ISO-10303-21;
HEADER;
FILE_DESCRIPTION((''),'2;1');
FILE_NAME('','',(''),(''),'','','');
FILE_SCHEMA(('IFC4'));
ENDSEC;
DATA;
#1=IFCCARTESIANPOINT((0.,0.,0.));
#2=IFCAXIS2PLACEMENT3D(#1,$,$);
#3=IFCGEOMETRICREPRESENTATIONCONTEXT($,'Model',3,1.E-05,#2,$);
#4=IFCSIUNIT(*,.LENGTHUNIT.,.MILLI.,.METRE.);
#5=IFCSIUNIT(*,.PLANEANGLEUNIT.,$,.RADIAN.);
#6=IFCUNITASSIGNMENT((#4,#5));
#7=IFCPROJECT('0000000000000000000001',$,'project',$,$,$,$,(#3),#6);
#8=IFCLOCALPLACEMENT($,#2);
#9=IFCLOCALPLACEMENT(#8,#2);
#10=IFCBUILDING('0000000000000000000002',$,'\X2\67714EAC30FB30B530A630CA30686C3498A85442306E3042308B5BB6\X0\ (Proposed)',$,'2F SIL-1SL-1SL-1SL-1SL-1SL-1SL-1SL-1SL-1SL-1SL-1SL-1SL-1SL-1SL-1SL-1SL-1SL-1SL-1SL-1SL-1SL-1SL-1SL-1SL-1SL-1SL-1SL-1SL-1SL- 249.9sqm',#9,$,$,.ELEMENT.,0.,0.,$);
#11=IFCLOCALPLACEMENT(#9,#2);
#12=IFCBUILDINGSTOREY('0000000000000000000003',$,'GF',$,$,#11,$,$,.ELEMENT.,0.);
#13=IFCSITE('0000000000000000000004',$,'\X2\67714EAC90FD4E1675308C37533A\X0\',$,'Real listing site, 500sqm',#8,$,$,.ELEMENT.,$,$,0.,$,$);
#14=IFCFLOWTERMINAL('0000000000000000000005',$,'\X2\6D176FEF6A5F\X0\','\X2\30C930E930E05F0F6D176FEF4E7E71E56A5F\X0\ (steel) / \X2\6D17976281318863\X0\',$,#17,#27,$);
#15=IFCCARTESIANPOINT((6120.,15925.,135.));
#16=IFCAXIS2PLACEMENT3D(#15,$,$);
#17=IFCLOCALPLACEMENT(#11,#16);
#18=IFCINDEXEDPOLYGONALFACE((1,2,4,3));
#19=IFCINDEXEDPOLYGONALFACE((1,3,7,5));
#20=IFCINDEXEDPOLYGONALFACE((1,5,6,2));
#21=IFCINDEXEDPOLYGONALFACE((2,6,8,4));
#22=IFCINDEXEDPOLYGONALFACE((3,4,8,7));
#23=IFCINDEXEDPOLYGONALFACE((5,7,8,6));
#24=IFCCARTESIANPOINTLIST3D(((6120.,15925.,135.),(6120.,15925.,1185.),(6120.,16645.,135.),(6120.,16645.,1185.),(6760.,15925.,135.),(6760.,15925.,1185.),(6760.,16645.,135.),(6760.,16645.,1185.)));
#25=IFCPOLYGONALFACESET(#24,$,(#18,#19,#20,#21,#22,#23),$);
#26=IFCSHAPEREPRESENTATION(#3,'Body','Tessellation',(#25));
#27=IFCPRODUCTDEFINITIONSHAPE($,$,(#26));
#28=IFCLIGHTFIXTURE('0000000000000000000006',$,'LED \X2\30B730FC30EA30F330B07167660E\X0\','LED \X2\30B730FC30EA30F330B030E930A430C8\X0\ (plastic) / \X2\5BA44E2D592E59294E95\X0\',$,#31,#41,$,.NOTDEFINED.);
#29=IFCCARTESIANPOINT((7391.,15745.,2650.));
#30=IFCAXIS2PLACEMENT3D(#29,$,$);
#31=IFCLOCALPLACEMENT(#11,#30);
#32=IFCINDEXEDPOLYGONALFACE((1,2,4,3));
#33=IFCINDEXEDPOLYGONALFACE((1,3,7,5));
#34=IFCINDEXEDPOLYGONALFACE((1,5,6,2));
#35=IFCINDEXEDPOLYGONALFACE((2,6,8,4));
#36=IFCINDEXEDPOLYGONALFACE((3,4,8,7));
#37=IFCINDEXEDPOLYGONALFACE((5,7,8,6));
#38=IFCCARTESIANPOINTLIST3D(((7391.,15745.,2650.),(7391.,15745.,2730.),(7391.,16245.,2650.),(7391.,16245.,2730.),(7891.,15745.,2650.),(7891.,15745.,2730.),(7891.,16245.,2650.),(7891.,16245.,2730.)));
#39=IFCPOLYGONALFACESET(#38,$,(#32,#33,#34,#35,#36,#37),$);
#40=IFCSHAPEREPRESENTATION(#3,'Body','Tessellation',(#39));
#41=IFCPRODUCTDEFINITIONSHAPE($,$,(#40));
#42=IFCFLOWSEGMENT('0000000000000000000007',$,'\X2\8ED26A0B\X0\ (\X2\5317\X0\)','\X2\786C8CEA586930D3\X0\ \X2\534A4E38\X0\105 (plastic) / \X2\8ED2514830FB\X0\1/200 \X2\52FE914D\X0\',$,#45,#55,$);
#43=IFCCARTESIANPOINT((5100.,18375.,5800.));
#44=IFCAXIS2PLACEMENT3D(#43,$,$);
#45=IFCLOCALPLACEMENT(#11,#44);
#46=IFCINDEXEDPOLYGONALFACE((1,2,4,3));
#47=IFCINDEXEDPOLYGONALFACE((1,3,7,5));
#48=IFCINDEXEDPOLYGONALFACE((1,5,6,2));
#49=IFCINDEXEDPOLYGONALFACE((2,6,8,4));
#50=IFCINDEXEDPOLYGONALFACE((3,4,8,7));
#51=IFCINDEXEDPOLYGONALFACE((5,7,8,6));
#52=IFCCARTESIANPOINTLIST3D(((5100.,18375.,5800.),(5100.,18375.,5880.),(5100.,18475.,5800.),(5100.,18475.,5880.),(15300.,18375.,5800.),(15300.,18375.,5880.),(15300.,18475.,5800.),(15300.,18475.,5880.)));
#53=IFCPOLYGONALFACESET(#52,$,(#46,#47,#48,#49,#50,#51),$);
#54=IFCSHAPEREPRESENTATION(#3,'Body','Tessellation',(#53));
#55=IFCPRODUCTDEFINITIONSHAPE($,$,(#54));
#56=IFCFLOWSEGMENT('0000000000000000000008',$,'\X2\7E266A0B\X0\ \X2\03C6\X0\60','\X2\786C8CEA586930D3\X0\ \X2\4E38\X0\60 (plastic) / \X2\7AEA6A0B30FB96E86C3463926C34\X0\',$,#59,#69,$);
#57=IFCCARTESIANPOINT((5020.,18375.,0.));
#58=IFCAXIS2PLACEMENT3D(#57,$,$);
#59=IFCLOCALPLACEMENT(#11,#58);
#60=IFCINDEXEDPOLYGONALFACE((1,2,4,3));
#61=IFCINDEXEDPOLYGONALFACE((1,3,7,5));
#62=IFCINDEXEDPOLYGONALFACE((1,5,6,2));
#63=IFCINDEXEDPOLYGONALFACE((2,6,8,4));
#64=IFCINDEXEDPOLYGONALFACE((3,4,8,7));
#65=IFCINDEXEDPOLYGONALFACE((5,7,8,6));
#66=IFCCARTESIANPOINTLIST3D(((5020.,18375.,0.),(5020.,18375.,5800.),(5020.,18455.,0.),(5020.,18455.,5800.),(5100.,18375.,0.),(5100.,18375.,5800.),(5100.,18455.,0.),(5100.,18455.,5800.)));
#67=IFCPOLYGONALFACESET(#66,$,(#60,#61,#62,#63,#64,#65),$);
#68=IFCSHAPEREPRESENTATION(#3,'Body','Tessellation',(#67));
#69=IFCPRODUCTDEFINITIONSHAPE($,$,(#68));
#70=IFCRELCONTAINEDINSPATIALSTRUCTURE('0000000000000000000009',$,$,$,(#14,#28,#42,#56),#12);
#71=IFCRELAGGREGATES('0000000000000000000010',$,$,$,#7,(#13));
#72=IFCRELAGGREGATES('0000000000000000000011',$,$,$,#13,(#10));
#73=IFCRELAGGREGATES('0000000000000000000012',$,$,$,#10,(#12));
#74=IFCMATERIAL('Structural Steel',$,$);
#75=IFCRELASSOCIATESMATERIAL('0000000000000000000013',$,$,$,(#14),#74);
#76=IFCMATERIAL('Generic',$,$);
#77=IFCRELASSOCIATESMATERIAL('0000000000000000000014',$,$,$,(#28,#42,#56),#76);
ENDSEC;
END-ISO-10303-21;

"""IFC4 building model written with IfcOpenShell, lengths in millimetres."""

from ifc_helpers import new_model, si_unit, frame, frame_2d, origin, place, context, project, spatial, rectangle, extrude, material, element, save


model = new_model("IFC4")

# Units and contexts
model_context = context("Model", 3, precision=1e-05, world=origin())
ifc_project = project(units=[si_unit("LENGTHUNIT", "METRE", prefix="MILLI"), si_unit("PLANEANGLEUNIT", "RADIAN")], contexts=[model_context])

# Site, building, storey
site_placement = place(None, origin())
site = spatial("IfcSite", under=ifc_project, at=site_placement, Name="東京都世田谷区", ObjectType="Real listing site, 500sqm", CompositionType="ELEMENT", RefElevation=0.0)
building_placement = place(site_placement, origin())
building = spatial("IfcBuilding", under=site, at=building_placement, Name="東京・サウナと水風呂のある家 (Proposed)", ObjectType="2F SIL-1SL-1SL-1SL-1SL-1SL-1SL-1SL-1SL-1SL-1SL-1SL-1SL-1SL-1SL-1SL-1SL-1SL-1SL-1SL-1SL-1SL-1SL-1SL-1SL-1SL-1SL-1SL-1SL-1SL- 249.9sqm", CompositionType="ELEMENT", ElevationOfRefHeight=0.0, ElevationOfTerrain=0.0)
storey_placement = place(building_placement, origin())
storey = spatial("IfcBuildingStorey", under=building, at=storey_placement, Name="GF", CompositionType="ELEMENT", Elevation=0.0)

# Flow terminal
ifc_material_1 = material(Name="Structural Steel")
flow_terminal_placement = place(storey_placement, frame((6120.0, 15925.0, 135.0)))
element("IfcFlowTerminal", 1, at=flow_terminal_placement, inside=storey, material=ifc_material_1, Name="洗濯機", Description="ドラム式洗濯乾燥機 (steel) / 洗面脱衣", context=model_context, shape_type="SweptSolid", body=[
    extrude(rectangle(XDim=640.0, YDim=720.0, at=frame_2d((320.0, 360.0))), frame((6120.0, 15925.0, 135.0)), (0.0, 0.0, 1.0), 1050.0),
])

# Light fixture
ifc_material_2 = material(Name="Generic")
light_fixture_placement = place(storey_placement, frame((7391.0, 15745.0, 2650.0)))
element("IfcLightFixture", 2, at=light_fixture_placement, inside=storey, material=ifc_material_2, Name="LED シーリング照明", Description="LED シーリングライト (plastic) / 室中央天井", PredefinedType="NOTDEFINED", context=model_context, shape_type="SweptSolid", body=[
    extrude(rectangle(XDim=500.0, YDim=500.0, at=frame_2d((250.0, 250.0))), frame((7391.0, 15745.0, 2650.0)), (0.0, 0.0, 1.0), 80.0),
])

# Flow segments
flow_segment_1_placement = place(storey_placement, frame((5100.0, 18375.0, 5800.0)))
element("IfcFlowSegment", 3, at=flow_segment_1_placement, inside=storey, material=ifc_material_2, Name="軒樋 (北)", Description="硬質塩ビ 半丸105 (plastic) / 軒先・1/200 勾配", context=model_context, shape_type="SweptSolid", body=[
    extrude(rectangle(XDim=10200.0, YDim=100.0, at=frame_2d((5100.0, 50.0))), frame((5100.0, 18375.0, 5800.0)), (0.0, 0.0, 1.0), 80.0),
])
flow_segment_2_placement = place(storey_placement, frame((5020.0, 18375.0, 0.0)))
element("IfcFlowSegment", 4, at=flow_segment_2_placement, inside=storey, material=ifc_material_2, Name="縦樋 φ60", Description="硬質塩ビ 丸60 (plastic) / 竪樋・雨水排水", context=model_context, shape_type="SweptSolid", body=[
    extrude(rectangle(XDim=80.0, YDim=80.0, at=frame_2d((40.0, 40.0))), frame((5020.0, 18375.0, 0.0)), (0.0, 0.0, 1.0), 5800.0),
])

save(model, "model.ifc")
